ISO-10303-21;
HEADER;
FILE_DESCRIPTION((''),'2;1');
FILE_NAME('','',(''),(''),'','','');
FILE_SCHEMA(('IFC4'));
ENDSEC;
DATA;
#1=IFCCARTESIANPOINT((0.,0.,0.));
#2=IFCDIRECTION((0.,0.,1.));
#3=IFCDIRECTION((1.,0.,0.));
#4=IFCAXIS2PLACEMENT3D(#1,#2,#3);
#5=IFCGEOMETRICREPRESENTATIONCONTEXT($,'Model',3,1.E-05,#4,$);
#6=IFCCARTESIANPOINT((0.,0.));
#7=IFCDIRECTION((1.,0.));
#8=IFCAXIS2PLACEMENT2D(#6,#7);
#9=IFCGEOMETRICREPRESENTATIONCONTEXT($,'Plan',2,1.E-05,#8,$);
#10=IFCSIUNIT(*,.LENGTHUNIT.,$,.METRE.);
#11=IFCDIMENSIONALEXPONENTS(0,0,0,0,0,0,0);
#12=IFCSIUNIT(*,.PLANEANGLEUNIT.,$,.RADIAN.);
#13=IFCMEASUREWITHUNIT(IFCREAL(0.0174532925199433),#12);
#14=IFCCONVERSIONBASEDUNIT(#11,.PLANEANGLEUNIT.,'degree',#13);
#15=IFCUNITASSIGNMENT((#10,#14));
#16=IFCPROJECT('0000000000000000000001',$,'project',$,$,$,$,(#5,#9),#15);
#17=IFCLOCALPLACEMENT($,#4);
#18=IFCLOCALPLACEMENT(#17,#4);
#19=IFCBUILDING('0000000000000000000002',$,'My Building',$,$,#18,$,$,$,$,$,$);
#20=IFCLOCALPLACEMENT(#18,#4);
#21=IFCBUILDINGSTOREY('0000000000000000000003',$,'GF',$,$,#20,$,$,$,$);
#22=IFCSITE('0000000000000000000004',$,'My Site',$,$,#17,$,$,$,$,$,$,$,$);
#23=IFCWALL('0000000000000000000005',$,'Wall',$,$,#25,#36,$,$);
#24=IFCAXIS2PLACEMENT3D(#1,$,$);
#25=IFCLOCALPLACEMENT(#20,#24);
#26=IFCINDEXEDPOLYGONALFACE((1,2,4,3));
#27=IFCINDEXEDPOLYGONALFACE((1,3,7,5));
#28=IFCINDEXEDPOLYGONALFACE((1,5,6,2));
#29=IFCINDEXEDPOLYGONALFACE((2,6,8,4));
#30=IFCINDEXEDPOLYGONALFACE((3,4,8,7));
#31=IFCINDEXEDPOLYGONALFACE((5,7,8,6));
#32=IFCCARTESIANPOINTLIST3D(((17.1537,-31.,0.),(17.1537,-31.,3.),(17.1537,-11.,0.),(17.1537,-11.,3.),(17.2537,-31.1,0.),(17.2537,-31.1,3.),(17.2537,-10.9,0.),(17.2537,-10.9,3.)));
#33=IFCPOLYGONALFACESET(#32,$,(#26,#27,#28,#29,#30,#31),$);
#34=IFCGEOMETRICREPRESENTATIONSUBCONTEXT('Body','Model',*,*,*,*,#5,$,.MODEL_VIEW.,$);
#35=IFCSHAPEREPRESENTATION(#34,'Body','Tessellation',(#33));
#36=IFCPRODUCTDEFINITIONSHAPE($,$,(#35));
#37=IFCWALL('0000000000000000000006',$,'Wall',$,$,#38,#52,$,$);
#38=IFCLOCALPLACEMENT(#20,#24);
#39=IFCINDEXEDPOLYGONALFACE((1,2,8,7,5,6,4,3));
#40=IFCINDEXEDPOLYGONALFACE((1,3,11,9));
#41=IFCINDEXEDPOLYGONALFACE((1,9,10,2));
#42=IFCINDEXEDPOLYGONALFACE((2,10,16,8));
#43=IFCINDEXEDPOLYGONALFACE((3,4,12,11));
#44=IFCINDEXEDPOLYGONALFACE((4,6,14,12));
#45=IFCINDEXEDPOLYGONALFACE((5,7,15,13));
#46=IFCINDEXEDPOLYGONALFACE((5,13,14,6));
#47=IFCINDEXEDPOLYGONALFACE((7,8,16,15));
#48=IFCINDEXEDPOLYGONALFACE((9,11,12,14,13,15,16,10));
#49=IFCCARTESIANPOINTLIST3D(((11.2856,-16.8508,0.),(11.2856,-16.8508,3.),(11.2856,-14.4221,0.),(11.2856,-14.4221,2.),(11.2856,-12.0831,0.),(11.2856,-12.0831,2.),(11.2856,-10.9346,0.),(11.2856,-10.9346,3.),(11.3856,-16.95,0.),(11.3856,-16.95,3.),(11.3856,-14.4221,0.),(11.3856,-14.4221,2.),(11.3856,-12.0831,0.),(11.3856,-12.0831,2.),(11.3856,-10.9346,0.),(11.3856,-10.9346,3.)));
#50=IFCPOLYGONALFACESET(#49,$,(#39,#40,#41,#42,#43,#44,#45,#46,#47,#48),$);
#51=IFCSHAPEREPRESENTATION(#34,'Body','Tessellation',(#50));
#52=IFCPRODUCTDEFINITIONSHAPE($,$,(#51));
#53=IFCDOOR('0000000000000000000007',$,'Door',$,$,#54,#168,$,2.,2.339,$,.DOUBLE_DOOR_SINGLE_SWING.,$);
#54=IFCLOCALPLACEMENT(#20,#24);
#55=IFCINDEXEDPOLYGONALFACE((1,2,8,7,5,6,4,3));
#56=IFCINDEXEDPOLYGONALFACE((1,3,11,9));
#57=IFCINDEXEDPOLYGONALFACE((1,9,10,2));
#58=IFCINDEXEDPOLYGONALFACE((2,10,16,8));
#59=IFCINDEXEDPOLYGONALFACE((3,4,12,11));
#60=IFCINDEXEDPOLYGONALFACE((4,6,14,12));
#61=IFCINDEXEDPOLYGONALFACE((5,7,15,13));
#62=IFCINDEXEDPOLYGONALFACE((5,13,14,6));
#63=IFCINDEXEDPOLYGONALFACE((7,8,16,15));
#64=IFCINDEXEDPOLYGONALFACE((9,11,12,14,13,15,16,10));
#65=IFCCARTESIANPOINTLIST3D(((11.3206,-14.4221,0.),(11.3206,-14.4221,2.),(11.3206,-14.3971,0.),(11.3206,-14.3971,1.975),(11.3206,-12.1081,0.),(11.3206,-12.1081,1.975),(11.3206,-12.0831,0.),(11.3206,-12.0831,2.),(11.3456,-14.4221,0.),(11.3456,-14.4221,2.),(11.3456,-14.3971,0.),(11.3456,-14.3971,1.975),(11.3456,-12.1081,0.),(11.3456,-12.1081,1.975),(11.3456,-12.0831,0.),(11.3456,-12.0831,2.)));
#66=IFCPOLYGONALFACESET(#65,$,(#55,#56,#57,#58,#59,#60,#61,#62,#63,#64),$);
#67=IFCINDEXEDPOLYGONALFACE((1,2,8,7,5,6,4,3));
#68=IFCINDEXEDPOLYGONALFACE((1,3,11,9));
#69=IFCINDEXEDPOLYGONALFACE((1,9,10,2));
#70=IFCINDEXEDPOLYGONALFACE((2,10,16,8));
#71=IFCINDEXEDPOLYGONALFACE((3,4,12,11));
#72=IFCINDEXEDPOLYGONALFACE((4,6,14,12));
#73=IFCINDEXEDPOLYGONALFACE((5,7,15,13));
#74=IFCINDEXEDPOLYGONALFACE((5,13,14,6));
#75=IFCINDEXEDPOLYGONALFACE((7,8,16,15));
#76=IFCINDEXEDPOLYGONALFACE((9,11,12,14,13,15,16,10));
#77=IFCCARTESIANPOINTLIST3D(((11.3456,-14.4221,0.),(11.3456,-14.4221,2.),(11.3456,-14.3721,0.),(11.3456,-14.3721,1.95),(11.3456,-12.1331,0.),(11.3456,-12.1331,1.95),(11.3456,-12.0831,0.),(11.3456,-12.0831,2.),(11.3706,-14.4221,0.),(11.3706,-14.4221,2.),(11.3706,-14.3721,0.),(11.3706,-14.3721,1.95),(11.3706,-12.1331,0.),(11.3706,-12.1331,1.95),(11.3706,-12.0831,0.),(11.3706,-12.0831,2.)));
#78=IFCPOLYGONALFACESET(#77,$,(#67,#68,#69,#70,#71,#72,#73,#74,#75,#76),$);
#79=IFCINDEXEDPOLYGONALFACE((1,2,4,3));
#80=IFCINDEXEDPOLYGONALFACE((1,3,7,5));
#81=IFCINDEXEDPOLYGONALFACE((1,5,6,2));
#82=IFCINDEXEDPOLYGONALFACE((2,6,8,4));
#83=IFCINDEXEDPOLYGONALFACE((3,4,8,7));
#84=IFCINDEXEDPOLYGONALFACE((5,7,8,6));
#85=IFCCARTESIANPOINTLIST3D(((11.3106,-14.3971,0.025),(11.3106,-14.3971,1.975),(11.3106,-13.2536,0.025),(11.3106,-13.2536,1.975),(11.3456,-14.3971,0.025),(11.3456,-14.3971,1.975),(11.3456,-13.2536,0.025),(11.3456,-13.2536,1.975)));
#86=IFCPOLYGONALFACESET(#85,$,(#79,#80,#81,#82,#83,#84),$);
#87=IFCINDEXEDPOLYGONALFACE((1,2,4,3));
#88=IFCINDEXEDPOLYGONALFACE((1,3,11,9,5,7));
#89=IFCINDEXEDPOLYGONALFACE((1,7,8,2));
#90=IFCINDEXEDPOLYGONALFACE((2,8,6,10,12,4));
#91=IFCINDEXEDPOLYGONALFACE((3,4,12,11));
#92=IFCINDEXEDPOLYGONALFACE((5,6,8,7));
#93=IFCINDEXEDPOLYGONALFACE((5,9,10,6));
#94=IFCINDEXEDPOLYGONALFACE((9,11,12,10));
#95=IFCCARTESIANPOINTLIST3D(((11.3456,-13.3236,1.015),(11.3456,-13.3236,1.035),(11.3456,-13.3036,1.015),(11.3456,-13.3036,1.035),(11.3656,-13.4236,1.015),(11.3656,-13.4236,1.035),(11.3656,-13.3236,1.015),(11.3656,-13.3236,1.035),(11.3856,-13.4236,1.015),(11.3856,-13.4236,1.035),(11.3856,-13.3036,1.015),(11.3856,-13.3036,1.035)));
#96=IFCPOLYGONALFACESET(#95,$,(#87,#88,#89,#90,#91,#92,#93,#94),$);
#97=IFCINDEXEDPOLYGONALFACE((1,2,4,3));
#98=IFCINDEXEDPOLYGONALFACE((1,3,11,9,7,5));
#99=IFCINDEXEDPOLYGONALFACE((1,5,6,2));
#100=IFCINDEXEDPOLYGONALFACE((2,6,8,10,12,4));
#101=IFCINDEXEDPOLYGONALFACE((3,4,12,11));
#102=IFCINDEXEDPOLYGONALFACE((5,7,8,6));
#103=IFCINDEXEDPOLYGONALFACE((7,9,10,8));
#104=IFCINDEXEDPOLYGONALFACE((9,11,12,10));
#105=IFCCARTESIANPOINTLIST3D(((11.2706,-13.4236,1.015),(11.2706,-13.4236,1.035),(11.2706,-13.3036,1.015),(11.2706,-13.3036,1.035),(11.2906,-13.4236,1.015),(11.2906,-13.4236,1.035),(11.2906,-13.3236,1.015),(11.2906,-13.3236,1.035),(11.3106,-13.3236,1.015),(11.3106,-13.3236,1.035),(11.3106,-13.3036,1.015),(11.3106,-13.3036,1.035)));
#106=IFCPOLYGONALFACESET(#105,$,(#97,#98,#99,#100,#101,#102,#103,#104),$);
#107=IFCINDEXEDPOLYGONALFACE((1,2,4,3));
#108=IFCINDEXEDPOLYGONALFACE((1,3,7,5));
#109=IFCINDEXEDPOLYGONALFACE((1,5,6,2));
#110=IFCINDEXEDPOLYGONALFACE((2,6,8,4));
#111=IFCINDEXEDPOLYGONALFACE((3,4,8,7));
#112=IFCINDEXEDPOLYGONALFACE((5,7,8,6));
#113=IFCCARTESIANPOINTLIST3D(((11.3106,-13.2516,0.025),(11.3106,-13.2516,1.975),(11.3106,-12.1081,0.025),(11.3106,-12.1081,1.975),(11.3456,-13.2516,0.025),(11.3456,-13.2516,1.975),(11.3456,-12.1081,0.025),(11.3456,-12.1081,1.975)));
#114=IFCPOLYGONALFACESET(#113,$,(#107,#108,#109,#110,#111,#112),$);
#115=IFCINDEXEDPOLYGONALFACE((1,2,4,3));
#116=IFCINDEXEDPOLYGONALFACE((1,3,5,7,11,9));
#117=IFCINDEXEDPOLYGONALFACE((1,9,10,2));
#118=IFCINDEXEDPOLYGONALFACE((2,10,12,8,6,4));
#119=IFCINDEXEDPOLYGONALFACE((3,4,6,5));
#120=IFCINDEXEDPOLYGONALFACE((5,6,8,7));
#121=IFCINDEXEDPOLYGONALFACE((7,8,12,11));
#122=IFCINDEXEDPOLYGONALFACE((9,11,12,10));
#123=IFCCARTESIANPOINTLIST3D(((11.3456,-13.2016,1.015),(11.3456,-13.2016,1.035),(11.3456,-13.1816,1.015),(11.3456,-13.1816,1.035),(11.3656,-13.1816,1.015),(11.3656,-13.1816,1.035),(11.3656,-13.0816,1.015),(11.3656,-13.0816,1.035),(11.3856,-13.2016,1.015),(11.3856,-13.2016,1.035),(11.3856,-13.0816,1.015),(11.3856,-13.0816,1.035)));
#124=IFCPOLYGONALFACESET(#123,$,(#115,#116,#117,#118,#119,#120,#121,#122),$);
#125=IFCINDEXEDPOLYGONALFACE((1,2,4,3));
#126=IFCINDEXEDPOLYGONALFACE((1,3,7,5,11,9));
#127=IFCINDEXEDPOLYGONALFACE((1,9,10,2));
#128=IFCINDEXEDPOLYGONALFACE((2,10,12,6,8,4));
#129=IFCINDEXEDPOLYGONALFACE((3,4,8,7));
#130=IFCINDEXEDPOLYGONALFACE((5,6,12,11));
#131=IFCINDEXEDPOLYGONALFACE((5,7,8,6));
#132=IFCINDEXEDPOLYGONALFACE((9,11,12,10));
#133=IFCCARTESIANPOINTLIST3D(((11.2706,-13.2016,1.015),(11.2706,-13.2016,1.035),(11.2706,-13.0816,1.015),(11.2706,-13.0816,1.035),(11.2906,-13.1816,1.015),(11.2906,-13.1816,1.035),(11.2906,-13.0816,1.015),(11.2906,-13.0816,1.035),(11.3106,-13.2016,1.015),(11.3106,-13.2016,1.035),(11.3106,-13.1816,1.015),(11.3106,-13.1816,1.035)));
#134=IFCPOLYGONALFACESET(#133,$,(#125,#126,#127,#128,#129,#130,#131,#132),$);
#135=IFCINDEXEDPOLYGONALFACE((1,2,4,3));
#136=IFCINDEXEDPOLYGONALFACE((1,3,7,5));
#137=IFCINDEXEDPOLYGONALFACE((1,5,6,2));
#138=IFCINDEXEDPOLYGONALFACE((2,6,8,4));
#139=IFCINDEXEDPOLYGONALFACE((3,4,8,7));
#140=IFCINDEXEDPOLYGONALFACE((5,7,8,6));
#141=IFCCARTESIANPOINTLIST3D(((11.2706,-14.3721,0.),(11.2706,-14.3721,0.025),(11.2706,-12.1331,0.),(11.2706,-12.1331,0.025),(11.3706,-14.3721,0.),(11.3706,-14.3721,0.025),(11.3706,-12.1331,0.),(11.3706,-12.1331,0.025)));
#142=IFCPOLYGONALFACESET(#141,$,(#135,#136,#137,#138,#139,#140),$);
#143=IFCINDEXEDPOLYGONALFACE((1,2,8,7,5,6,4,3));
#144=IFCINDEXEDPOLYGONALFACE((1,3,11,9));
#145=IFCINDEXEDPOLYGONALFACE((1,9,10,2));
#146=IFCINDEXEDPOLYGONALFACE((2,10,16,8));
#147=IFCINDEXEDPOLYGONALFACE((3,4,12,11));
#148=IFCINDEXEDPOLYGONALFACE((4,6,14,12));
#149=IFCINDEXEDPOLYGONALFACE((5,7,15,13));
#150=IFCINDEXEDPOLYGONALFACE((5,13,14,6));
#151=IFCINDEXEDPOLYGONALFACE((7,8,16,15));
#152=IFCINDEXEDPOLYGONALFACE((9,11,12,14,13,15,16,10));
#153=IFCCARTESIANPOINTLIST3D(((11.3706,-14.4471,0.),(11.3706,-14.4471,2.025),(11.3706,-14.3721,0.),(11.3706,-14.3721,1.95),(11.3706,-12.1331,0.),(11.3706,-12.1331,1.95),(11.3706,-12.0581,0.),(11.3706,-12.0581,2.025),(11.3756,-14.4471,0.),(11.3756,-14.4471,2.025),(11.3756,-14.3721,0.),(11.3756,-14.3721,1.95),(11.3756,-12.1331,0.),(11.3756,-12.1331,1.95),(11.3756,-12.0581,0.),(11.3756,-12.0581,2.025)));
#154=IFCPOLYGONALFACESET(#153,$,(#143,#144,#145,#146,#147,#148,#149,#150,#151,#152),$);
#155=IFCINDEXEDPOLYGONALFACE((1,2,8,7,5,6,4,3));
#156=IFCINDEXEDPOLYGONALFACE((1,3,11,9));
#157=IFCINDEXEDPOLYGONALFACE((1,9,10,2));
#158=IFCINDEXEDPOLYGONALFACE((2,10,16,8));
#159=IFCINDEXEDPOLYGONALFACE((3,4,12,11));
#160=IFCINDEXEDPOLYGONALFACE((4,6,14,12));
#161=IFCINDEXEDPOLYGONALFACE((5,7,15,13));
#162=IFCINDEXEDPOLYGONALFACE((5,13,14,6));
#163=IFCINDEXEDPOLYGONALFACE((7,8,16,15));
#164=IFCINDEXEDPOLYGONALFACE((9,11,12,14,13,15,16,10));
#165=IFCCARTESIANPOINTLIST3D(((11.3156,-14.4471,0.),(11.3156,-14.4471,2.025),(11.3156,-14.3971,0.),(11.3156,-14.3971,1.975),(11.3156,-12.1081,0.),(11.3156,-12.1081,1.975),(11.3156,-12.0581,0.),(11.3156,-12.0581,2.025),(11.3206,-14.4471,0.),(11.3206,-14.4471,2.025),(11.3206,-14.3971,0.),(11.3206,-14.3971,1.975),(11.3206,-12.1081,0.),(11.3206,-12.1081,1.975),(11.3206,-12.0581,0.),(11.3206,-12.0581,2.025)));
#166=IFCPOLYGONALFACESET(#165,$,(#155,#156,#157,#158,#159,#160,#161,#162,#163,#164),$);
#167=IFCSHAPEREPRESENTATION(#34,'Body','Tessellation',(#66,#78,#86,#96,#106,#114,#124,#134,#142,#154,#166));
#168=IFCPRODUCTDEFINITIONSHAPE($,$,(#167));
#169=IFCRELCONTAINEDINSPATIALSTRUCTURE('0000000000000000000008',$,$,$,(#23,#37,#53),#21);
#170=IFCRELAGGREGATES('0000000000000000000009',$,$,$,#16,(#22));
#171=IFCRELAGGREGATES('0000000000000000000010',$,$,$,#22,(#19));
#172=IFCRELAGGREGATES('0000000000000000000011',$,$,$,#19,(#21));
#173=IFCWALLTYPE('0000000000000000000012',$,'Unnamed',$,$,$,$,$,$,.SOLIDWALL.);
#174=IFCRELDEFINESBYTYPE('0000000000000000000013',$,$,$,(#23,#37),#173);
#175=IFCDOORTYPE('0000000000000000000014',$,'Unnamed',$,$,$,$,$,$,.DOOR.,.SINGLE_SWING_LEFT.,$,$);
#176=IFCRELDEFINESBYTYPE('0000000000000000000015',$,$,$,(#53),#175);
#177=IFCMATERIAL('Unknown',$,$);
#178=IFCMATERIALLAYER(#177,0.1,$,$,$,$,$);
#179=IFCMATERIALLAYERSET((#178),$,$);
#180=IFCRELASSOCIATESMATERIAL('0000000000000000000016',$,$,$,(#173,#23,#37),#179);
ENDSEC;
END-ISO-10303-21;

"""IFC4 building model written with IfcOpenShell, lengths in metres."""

from ifc_helpers import new_model, entity, si_unit, converted_unit, frame, origin_with_axes, origin_2d_with_axis, place, context, subcontext, project, spatial, line, indexed_curve, outline, extrude, shape, source, transform, mapped, material, layer, layer_set, layer_usage, type_object, type_shapes, element, fill, save


model = new_model("IFC4")

# Units and contexts
model_context = context("Model", 3, precision=1e-05, world=origin_with_axes())
plan_context = context("Plan", 2, precision=1e-05, world=origin_2d_with_axis())
body_context_1 = subcontext(model_context, "Body", "Model", "MODEL_VIEW")
body_context_2 = subcontext(plan_context, "Body", "Plan", "PLAN_VIEW")
ifc_project = project(units=[si_unit("LENGTHUNIT", "METRE"), converted_unit("PLANEANGLEUNIT", "degree", entity("IfcReal", 0.0174532925199433), si_unit("PLANEANGLEUNIT", "RADIAN"), dimensions=[0, 0, 0, 0, 0, 0, 0])], contexts=[model_context, plan_context])

# Site, building, storey
site_placement = place(None, origin_with_axes())
site = spatial("IfcSite", under=ifc_project, at=site_placement, Name="My Site")
building_placement = place(site_placement, origin_with_axes())
building = spatial("IfcBuilding", under=site, at=building_placement, Name="My Building")
storey_placement = place(building_placement, origin_with_axes())
storey = spatial("IfcBuildingStorey", under=building, at=storey_placement, Name="GF")

# Shared definitions
ifc_material = material(Name="Unknown")

# Shared definitions
ifc_layer_1 = layer(ifc_material, 0.1)
ifc_layer_set_1 = layer_set([ifc_layer_1])
wall_type = type_object("IfcWallType", Name="Unnamed", PredefinedType="SOLIDWALL", material=ifc_layer_set_1)

# Shared definitions
shared_shape_1 = source(origin_with_axes(), body_context_1, "Body", "SweptSolid", [
    extrude(outline(indexed_curve([(0.0, 0.0), (2.339, 0.0), (2.339, 2.0), (0.0, 2.0)], segments=[line(1, 2, 3, 4, 1)])), frame((0.0, -0.6, 0.0), z_axis=(0.0, -1.0, 0.0), x_axis=(1.0, 0.0, 0.0)), (0.0, 0.0, -1.0), 1.2),
])
door_type_1 = type_object("IfcDoorType", Name="Unnamed", OperationType="SINGLE_SWING_LEFT", PredefinedType="DOOR")
shared_shape_2 = source(origin_with_axes(), body_context_1, "Body", "SweptSolid", [
    extrude(outline(indexed_curve([(0.0, 0.0), (0.0, 2.0), (2.339, 2.0), (2.339, 0.0), (2.314, 0.0), (2.314, 1.975), (0.025, 1.975), (0.025, 0.0)], segments=[line(1, 2, 3, 4, 5, 6, 7, 8, 1)])), frame((0.0, 0.025, 0.0), z_axis=(0.0, -1.0, 0.0), x_axis=(1.0, 0.0, 0.0)), (0.0, 0.0, -1.0), 0.025),
    extrude(outline(indexed_curve([(0.0, 0.0), (0.0, 2.0), (2.339, 2.0), (2.339, 0.0), (2.289, 0.0), (2.289, 1.95), (0.05, 1.95), (0.05, 0.0)], segments=[line(1, 2, 3, 4, 5, 6, 7, 8, 1)])), frame((0.0, 0.0, 0.0), z_axis=(0.0, -1.0, 0.0), x_axis=(1.0, 0.0, 0.0)), (0.0, 0.0, -1.0), 0.025),
    extrude(outline(indexed_curve([(0.0, 0.0), (1.1435, 0.0), (1.1435, 0.035), (0.0, 0.035)], segments=[line(1, 2, 3, 4, 1)])), frame((0.025, 0.025, 0.025), z_axis=(0.0, 0.0, 1.0), x_axis=(1.0, 0.0, 0.0)), (0.0, 0.0, 1.0), 1.95),
    extrude(outline(indexed_curve([(0.0, 0.0), (0.0, -0.04), (-0.12, -0.04), (-0.12, -0.02), (-0.02, -0.02), (-0.02, 0.0)], segments=[line(1, 2, 3, 4, 5, 6, 1)])), frame((1.1185, 0.025, 1.015), z_axis=(0.0, 0.0, 1.0), x_axis=(1.0, 0.0, 0.0)), (0.0, 0.0, 1.0), 0.02),
    extrude(outline(indexed_curve([(0.0, 0.0), (0.0, 0.04), (-0.12, 0.04), (-0.12, 0.02), (-0.02, 0.02), (-0.02, 0.0)], segments=[line(1, 2, 3, 4, 5, 6, 1)])), frame((1.1185, 0.06, 1.015), z_axis=(0.0, 0.0, 1.0), x_axis=(1.0, 0.0, 0.0)), (0.0, 0.0, 1.0), 0.02),
    extrude(outline(indexed_curve([(0.0, 0.0), (-1.1435, 0.0), (-1.1435, 0.035), (0.0, 0.035)], segments=[line(1, 2, 3, 4, 1)])), frame((2.314, 0.025, 0.025), z_axis=(0.0, 0.0, 1.0), x_axis=(1.0, 0.0, 0.0)), (0.0, 0.0, 1.0), 1.95),
    extrude(outline(indexed_curve([(0.0, 0.0), (0.0, -0.04), (0.12, -0.04), (0.12, -0.02), (0.02, -0.02), (0.02, 0.0)], segments=[line(1, 2, 3, 4, 5, 6, 1)])), frame((1.2205, 0.025, 1.015), z_axis=(0.0, 0.0, 1.0), x_axis=(1.0, 0.0, 0.0)), (0.0, 0.0, 1.0), 0.02),
    extrude(outline(indexed_curve([(0.0, 0.0), (0.0, 0.04), (0.12, 0.04), (0.12, 0.02), (0.02, 0.02), (0.02, 0.0)], segments=[line(1, 2, 3, 4, 5, 6, 1)])), frame((1.2205, 0.06, 1.015), z_axis=(0.0, 0.0, 1.0), x_axis=(1.0, 0.0, 0.0)), (0.0, 0.0, 1.0), 0.02),
    extrude(outline(indexed_curve([(0.0, 0.0), (2.239, 0.0), (2.239, 0.1), (0.0, 0.1)], segments=[line(1, 2, 3, 4, 1)])), frame((0.05, 0.0, 0.0), z_axis=(0.0, 0.0, 1.0), x_axis=(1.0, 0.0, 0.0)), (0.0, 0.0, 1.0), 0.025),
    extrude(outline(indexed_curve([(0.0, 0.0), (0.0, 2.025), (2.389, 2.025), (2.389, 0.0), (2.314, 0.0), (2.314, 1.95), (0.075, 1.95), (0.075, 0.0)], segments=[line(1, 2, 3, 4, 5, 6, 7, 8, 1)])), frame((-0.025, -0.005, 0.0), z_axis=(0.0, -1.0, 0.0), x_axis=(1.0, 0.0, 0.0)), (0.0, 0.0, -1.0), 0.005),
    extrude(outline(indexed_curve([(0.0, 0.0), (0.0, 2.025), (2.389, 2.025), (2.389, 0.0), (2.339, 0.0), (2.339, 1.975), (0.05, 1.975), (0.05, 0.0)], segments=[line(1, 2, 3, 4, 5, 6, 7, 8, 1)])), frame((-0.025, 0.05, 0.0), z_axis=(0.0, -1.0, 0.0), x_axis=(1.0, 0.0, 0.0)), (0.0, 0.0, -1.0), 0.005),
])
shared_shape_3 = source(origin_with_axes(), body_context_2, "Body", "Curve2D", [
    entity("IfcIndexedPolyCurve", entity("IfcCartesianPointList2D", [[0.0, 0.0], [0.0, 0.05], [0.025, 0.05], [0.025, 0.025], [0.05, 0.025], [0.05, 0.0]]), [entity("IfcLineIndex", [1, 2, 3, 4, 5, 6, 1])]),
    entity("IfcIndexedPolyCurve", entity("IfcCartesianPointList2D", [[2.339, 0.0], [2.339, 0.05], [2.314, 0.05], [2.314, 0.025], [2.289, 0.025], [2.289, 0.0]]), [entity("IfcLineIndex", [1, 2, 3, 4, 5, 6, 1])]),
    entity("IfcTrimmedCurve", entity("IfcEllipse", entity("IfcAxis2Placement2D", entity("IfcCartesianPoint", [0.06, 0.05]), entity("IfcDirection", [1.0, 0.0])), 1.1095, 1.1445), [entity("IfcCartesianPoint", [1.1695, 0.05])], [entity("IfcCartesianPoint", [0.06, 1.1945])], True, "CARTESIAN"),
    entity("IfcIndexedPolyCurve", entity("IfcCartesianPointList2D", [[0.025, 0.05], [0.06, 0.05], [0.06, 1.1945], [0.025, 1.1945]]), [entity("IfcLineIndex", [1, 2, 3, 4, 1])]),
    entity("IfcTrimmedCurve", entity("IfcEllipse", entity("IfcAxis2Placement2D", entity("IfcCartesianPoint", [2.279, 0.05]), entity("IfcDirection", [1.0, 0.0])), 1.1095, 1.1445), [entity("IfcCartesianPoint", [2.279, 1.1945])], [entity("IfcCartesianPoint", [1.1695, 0.05])], True, "CARTESIAN"),
    entity("IfcIndexedPolyCurve", entity("IfcCartesianPointList2D", [[2.314, 0.05], [2.279, 0.05], [2.279, 1.1945], [2.314, 1.1945]]), [entity("IfcLineIndex", [1, 2, 3, 4, 1])]),
])
type_shapes(door_type_1, [shared_shape_2, shared_shape_3])

# Wall
ifc_layer_usage_1 = layer_usage(ifc_layer_set_1, "AXIS2", "POSITIVE", 0.0)
wall_1_placement = place(storey_placement, frame((17.1537, -11.0, 0.0), z_axis=(0.0, 0.0, 1.0), x_axis=(0.0, -1.0, 0.0)))
element("IfcWall", 1, at=wall_1_placement, inside=storey, type_object=wall_type, material=ifc_layer_usage_1, Name="Wall", context=body_context_1, shape_type="SweptSolid", body=[
    extrude(outline(indexed_curve([(0.0, 0.0), (-0.1, 0.1), (20.1, 0.1), (20.0, 0.0)], segments=[line(1, 2, 3, 4, 1)])), origin_with_axes(), (0.0, 0.0, 1.0), 3.0),
])

# Wall, opening, door
ifc_layer_usage_2 = layer_usage(ifc_layer_set_1, "AXIS2", "POSITIVE", 0.0)
wall_2_placement = place(storey_placement, frame((11.2856, -10.9346, 0.0), z_axis=(0.0, 0.0, 1.0), x_axis=(0.0, -1.0, 0.0)))
wall_2 = element("IfcWall", 2, at=wall_2_placement, inside=storey, type_object=wall_type, material=ifc_layer_usage_2, Name="Wall", context=body_context_1, shape_type="SweptSolid", body=[
    extrude(outline(indexed_curve([(0.0, 0.0), (0.0, 0.1), (6.0154, 0.1), (5.9162, 0.0)], segments=[line(1, 2, 3, 4, 1)])), origin_with_axes(), (0.0, 0.0, 1.0), 3.0),
])
opening_1_placement = place(wall_2_placement, frame((3.4875, 0.085, 0.0), z_axis=(0.0, 0.0, 1.0), x_axis=(-1.0, 0.0, 0.0)))
opening_1 = element("IfcOpeningElement", 3, at=opening_1_placement, cuts=wall_2, PredefinedType="OPENING", context=body_context_1, shape_type="MappedRepresentation", body=[
    mapped(shared_shape_1, transform((0.0, 0.0, 0.0), x_axis=(1.0, 0.0, 0.0), y_axis=(0.0, 1.0, 0.0), z_axis=(0.0, 0.0, 1.0), scale=1.0)),
])
door_1_placement = place(opening_1_placement, frame((0.0, 0.0, 0.0), z_axis=(0.0, 0.0, 1.0), x_axis=(1.0, 0.0, 0.0)))
door_1 = element("IfcDoor", 4, at=door_1_placement, inside=storey, type_object=door_type_1, Name="Door", OperationType="DOUBLE_DOOR_SINGLE_SWING", OverallHeight=2.0, OverallWidth=2.339, shapes=[
    shape(body_context_1, "Body", "MappedRepresentation", [mapped(shared_shape_2, transform((0.0, 0.0, 0.0), x_axis=(1.0, 0.0, 0.0), y_axis=(0.0, 1.0, 0.0), z_axis=(0.0, 0.0, 1.0), scale=1.0))]),
    shape(body_context_2, "Body", "MappedRepresentation", [mapped(shared_shape_3, transform((0.0, 0.0, 0.0), x_axis=(1.0, 0.0, 0.0), y_axis=(0.0, 1.0, 0.0), z_axis=(0.0, 0.0, 1.0), scale=1.0))]),
])
fill(opening_1, door_1)

save(model, "model.ifc")
